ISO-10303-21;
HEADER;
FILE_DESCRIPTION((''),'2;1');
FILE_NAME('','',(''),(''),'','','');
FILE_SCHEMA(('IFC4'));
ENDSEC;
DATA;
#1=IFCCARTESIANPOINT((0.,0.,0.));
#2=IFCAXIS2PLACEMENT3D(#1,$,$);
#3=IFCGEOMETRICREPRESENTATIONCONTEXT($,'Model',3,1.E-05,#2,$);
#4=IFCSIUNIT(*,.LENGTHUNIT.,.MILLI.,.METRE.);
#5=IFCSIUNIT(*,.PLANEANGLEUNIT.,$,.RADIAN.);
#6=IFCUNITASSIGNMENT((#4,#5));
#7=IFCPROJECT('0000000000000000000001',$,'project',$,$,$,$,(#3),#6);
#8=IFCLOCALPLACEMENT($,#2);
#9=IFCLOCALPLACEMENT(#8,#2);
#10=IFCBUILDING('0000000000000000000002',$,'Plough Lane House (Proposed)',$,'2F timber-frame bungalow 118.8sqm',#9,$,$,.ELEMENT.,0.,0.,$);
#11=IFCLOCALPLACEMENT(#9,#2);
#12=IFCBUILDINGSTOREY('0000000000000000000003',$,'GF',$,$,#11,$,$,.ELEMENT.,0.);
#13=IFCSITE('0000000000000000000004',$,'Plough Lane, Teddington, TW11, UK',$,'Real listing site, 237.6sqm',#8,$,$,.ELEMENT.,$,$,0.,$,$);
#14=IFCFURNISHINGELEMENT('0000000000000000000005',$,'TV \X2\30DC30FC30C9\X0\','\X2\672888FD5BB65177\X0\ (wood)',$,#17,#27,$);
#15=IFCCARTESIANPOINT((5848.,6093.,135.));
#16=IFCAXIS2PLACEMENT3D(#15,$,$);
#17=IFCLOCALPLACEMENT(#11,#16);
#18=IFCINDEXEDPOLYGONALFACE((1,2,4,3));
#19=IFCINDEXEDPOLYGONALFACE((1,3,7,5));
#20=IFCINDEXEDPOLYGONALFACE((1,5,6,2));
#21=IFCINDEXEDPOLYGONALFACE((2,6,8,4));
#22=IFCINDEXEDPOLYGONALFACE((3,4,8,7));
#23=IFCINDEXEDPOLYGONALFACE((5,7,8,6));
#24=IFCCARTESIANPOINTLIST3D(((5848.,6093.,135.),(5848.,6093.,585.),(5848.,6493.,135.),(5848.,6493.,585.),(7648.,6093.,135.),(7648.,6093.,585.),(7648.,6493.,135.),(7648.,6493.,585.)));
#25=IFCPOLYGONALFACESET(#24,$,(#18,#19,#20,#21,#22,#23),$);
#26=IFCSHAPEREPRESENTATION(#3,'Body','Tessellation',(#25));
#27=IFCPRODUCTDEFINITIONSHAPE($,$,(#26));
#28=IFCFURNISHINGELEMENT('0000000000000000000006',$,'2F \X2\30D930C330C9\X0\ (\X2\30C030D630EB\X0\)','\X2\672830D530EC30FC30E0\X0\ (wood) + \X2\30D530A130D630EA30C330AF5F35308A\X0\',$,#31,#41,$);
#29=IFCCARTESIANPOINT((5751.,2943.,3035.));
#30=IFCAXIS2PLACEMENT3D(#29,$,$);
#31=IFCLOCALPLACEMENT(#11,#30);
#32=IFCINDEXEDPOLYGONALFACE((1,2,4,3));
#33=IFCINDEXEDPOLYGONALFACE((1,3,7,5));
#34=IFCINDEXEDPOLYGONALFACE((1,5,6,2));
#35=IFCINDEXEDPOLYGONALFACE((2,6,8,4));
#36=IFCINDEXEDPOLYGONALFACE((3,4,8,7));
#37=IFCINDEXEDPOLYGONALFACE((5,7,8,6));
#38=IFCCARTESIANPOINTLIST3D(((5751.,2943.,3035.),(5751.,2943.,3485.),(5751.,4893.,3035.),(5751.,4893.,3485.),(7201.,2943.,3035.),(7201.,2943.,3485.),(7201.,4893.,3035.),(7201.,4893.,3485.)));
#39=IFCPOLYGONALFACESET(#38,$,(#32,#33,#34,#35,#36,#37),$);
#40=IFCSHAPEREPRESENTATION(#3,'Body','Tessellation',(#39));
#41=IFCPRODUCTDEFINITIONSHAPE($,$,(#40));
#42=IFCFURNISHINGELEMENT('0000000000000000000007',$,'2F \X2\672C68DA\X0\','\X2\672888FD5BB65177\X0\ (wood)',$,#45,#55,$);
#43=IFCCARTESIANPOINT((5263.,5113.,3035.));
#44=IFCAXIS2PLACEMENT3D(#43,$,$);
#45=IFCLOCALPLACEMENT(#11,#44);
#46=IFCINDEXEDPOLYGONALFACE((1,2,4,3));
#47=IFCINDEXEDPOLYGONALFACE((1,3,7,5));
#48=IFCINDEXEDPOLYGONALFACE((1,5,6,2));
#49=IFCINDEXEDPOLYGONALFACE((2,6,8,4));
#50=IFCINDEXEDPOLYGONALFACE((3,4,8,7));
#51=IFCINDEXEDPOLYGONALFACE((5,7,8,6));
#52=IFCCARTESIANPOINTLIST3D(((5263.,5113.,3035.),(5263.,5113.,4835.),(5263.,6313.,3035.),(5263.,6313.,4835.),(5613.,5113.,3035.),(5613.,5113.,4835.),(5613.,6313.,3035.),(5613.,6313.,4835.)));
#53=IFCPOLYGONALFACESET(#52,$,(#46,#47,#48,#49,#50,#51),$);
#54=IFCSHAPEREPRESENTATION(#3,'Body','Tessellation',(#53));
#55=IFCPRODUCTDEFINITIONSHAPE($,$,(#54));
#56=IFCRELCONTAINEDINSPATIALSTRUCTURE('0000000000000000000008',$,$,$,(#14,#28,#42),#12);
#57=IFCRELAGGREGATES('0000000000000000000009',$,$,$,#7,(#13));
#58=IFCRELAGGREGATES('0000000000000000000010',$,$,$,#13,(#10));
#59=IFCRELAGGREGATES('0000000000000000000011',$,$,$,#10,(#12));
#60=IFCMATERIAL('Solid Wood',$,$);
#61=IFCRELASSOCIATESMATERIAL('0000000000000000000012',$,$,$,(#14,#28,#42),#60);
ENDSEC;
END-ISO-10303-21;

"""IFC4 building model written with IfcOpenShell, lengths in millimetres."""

from ifc_helpers import new_model, si_unit, frame, frame_2d, origin, place, context, project, spatial, rectangle, extrude, material, element, save


model = new_model("IFC4")

# Units and contexts
model_context = context("Model", 3, precision=1e-05, world=origin())
ifc_project = project(units=[si_unit("LENGTHUNIT", "METRE", prefix="MILLI"), si_unit("PLANEANGLEUNIT", "RADIAN")], contexts=[model_context])

# Site, building, storey
site_placement = place(None, origin())
site = spatial("IfcSite", under=ifc_project, at=site_placement, Name="Plough Lane, Teddington, TW11, UK", ObjectType="Real listing site, 237.6sqm", CompositionType="ELEMENT", RefElevation=0.0)
building_placement = place(site_placement, origin())
building = spatial("IfcBuilding", under=site, at=building_placement, Name="Plough Lane House (Proposed)", ObjectType="2F timber-frame bungalow 118.8sqm", CompositionType="ELEMENT", ElevationOfRefHeight=0.0, ElevationOfTerrain=0.0)
storey_placement = place(building_placement, origin())
storey = spatial("IfcBuildingStorey", under=building, at=storey_placement, Name="GF", CompositionType="ELEMENT", Elevation=0.0)

# Shared definitions
ifc_material_1 = material(Name="Solid Wood")

# Furnishing elements
furnishing_1_placement = place(storey_placement, frame((5848.0, 6093.0, 135.0)))
element("IfcFurnishingElement", 1, at=furnishing_1_placement, inside=storey, material=ifc_material_1, Name="TV ボード", Description="木製家具 (wood)", context=model_context, shape_type="SweptSolid", body=[
    extrude(rectangle(XDim=1800.0, YDim=400.0, at=frame_2d((900.0, 200.0))), frame((5848.0, 6093.0, 135.0)), (0.0, 0.0, 1.0), 450.0),
])
furnishing_2_placement = place(storey_placement, frame((5751.0, 2943.0, 3035.0)))
element("IfcFurnishingElement", 2, at=furnishing_2_placement, inside=storey, material=ifc_material_1, Name="2F ベッド (ダブル)", Description="木フレーム (wood) + ファブリック張り", context=model_context, shape_type="SweptSolid", body=[
    extrude(rectangle(XDim=1450.0, YDim=1950.0, at=frame_2d((725.0, 975.0))), frame((5751.0, 2943.0, 3035.0)), (0.0, 0.0, 1.0), 450.0),
])
furnishing_3_placement = place(storey_placement, frame((5263.0, 5113.0, 3035.0)))
element("IfcFurnishingElement", 3, at=furnishing_3_placement, inside=storey, material=ifc_material_1, Name="2F 本棚", Description="木製家具 (wood)", context=model_context, shape_type="SweptSolid", body=[
    extrude(rectangle(XDim=350.0, YDim=1200.0, at=frame_2d((175.0, 600.0))), frame((5263.0, 5113.0, 3035.0)), (0.0, 0.0, 1.0), 1800.0),
])

save(model, "model.ifc")
